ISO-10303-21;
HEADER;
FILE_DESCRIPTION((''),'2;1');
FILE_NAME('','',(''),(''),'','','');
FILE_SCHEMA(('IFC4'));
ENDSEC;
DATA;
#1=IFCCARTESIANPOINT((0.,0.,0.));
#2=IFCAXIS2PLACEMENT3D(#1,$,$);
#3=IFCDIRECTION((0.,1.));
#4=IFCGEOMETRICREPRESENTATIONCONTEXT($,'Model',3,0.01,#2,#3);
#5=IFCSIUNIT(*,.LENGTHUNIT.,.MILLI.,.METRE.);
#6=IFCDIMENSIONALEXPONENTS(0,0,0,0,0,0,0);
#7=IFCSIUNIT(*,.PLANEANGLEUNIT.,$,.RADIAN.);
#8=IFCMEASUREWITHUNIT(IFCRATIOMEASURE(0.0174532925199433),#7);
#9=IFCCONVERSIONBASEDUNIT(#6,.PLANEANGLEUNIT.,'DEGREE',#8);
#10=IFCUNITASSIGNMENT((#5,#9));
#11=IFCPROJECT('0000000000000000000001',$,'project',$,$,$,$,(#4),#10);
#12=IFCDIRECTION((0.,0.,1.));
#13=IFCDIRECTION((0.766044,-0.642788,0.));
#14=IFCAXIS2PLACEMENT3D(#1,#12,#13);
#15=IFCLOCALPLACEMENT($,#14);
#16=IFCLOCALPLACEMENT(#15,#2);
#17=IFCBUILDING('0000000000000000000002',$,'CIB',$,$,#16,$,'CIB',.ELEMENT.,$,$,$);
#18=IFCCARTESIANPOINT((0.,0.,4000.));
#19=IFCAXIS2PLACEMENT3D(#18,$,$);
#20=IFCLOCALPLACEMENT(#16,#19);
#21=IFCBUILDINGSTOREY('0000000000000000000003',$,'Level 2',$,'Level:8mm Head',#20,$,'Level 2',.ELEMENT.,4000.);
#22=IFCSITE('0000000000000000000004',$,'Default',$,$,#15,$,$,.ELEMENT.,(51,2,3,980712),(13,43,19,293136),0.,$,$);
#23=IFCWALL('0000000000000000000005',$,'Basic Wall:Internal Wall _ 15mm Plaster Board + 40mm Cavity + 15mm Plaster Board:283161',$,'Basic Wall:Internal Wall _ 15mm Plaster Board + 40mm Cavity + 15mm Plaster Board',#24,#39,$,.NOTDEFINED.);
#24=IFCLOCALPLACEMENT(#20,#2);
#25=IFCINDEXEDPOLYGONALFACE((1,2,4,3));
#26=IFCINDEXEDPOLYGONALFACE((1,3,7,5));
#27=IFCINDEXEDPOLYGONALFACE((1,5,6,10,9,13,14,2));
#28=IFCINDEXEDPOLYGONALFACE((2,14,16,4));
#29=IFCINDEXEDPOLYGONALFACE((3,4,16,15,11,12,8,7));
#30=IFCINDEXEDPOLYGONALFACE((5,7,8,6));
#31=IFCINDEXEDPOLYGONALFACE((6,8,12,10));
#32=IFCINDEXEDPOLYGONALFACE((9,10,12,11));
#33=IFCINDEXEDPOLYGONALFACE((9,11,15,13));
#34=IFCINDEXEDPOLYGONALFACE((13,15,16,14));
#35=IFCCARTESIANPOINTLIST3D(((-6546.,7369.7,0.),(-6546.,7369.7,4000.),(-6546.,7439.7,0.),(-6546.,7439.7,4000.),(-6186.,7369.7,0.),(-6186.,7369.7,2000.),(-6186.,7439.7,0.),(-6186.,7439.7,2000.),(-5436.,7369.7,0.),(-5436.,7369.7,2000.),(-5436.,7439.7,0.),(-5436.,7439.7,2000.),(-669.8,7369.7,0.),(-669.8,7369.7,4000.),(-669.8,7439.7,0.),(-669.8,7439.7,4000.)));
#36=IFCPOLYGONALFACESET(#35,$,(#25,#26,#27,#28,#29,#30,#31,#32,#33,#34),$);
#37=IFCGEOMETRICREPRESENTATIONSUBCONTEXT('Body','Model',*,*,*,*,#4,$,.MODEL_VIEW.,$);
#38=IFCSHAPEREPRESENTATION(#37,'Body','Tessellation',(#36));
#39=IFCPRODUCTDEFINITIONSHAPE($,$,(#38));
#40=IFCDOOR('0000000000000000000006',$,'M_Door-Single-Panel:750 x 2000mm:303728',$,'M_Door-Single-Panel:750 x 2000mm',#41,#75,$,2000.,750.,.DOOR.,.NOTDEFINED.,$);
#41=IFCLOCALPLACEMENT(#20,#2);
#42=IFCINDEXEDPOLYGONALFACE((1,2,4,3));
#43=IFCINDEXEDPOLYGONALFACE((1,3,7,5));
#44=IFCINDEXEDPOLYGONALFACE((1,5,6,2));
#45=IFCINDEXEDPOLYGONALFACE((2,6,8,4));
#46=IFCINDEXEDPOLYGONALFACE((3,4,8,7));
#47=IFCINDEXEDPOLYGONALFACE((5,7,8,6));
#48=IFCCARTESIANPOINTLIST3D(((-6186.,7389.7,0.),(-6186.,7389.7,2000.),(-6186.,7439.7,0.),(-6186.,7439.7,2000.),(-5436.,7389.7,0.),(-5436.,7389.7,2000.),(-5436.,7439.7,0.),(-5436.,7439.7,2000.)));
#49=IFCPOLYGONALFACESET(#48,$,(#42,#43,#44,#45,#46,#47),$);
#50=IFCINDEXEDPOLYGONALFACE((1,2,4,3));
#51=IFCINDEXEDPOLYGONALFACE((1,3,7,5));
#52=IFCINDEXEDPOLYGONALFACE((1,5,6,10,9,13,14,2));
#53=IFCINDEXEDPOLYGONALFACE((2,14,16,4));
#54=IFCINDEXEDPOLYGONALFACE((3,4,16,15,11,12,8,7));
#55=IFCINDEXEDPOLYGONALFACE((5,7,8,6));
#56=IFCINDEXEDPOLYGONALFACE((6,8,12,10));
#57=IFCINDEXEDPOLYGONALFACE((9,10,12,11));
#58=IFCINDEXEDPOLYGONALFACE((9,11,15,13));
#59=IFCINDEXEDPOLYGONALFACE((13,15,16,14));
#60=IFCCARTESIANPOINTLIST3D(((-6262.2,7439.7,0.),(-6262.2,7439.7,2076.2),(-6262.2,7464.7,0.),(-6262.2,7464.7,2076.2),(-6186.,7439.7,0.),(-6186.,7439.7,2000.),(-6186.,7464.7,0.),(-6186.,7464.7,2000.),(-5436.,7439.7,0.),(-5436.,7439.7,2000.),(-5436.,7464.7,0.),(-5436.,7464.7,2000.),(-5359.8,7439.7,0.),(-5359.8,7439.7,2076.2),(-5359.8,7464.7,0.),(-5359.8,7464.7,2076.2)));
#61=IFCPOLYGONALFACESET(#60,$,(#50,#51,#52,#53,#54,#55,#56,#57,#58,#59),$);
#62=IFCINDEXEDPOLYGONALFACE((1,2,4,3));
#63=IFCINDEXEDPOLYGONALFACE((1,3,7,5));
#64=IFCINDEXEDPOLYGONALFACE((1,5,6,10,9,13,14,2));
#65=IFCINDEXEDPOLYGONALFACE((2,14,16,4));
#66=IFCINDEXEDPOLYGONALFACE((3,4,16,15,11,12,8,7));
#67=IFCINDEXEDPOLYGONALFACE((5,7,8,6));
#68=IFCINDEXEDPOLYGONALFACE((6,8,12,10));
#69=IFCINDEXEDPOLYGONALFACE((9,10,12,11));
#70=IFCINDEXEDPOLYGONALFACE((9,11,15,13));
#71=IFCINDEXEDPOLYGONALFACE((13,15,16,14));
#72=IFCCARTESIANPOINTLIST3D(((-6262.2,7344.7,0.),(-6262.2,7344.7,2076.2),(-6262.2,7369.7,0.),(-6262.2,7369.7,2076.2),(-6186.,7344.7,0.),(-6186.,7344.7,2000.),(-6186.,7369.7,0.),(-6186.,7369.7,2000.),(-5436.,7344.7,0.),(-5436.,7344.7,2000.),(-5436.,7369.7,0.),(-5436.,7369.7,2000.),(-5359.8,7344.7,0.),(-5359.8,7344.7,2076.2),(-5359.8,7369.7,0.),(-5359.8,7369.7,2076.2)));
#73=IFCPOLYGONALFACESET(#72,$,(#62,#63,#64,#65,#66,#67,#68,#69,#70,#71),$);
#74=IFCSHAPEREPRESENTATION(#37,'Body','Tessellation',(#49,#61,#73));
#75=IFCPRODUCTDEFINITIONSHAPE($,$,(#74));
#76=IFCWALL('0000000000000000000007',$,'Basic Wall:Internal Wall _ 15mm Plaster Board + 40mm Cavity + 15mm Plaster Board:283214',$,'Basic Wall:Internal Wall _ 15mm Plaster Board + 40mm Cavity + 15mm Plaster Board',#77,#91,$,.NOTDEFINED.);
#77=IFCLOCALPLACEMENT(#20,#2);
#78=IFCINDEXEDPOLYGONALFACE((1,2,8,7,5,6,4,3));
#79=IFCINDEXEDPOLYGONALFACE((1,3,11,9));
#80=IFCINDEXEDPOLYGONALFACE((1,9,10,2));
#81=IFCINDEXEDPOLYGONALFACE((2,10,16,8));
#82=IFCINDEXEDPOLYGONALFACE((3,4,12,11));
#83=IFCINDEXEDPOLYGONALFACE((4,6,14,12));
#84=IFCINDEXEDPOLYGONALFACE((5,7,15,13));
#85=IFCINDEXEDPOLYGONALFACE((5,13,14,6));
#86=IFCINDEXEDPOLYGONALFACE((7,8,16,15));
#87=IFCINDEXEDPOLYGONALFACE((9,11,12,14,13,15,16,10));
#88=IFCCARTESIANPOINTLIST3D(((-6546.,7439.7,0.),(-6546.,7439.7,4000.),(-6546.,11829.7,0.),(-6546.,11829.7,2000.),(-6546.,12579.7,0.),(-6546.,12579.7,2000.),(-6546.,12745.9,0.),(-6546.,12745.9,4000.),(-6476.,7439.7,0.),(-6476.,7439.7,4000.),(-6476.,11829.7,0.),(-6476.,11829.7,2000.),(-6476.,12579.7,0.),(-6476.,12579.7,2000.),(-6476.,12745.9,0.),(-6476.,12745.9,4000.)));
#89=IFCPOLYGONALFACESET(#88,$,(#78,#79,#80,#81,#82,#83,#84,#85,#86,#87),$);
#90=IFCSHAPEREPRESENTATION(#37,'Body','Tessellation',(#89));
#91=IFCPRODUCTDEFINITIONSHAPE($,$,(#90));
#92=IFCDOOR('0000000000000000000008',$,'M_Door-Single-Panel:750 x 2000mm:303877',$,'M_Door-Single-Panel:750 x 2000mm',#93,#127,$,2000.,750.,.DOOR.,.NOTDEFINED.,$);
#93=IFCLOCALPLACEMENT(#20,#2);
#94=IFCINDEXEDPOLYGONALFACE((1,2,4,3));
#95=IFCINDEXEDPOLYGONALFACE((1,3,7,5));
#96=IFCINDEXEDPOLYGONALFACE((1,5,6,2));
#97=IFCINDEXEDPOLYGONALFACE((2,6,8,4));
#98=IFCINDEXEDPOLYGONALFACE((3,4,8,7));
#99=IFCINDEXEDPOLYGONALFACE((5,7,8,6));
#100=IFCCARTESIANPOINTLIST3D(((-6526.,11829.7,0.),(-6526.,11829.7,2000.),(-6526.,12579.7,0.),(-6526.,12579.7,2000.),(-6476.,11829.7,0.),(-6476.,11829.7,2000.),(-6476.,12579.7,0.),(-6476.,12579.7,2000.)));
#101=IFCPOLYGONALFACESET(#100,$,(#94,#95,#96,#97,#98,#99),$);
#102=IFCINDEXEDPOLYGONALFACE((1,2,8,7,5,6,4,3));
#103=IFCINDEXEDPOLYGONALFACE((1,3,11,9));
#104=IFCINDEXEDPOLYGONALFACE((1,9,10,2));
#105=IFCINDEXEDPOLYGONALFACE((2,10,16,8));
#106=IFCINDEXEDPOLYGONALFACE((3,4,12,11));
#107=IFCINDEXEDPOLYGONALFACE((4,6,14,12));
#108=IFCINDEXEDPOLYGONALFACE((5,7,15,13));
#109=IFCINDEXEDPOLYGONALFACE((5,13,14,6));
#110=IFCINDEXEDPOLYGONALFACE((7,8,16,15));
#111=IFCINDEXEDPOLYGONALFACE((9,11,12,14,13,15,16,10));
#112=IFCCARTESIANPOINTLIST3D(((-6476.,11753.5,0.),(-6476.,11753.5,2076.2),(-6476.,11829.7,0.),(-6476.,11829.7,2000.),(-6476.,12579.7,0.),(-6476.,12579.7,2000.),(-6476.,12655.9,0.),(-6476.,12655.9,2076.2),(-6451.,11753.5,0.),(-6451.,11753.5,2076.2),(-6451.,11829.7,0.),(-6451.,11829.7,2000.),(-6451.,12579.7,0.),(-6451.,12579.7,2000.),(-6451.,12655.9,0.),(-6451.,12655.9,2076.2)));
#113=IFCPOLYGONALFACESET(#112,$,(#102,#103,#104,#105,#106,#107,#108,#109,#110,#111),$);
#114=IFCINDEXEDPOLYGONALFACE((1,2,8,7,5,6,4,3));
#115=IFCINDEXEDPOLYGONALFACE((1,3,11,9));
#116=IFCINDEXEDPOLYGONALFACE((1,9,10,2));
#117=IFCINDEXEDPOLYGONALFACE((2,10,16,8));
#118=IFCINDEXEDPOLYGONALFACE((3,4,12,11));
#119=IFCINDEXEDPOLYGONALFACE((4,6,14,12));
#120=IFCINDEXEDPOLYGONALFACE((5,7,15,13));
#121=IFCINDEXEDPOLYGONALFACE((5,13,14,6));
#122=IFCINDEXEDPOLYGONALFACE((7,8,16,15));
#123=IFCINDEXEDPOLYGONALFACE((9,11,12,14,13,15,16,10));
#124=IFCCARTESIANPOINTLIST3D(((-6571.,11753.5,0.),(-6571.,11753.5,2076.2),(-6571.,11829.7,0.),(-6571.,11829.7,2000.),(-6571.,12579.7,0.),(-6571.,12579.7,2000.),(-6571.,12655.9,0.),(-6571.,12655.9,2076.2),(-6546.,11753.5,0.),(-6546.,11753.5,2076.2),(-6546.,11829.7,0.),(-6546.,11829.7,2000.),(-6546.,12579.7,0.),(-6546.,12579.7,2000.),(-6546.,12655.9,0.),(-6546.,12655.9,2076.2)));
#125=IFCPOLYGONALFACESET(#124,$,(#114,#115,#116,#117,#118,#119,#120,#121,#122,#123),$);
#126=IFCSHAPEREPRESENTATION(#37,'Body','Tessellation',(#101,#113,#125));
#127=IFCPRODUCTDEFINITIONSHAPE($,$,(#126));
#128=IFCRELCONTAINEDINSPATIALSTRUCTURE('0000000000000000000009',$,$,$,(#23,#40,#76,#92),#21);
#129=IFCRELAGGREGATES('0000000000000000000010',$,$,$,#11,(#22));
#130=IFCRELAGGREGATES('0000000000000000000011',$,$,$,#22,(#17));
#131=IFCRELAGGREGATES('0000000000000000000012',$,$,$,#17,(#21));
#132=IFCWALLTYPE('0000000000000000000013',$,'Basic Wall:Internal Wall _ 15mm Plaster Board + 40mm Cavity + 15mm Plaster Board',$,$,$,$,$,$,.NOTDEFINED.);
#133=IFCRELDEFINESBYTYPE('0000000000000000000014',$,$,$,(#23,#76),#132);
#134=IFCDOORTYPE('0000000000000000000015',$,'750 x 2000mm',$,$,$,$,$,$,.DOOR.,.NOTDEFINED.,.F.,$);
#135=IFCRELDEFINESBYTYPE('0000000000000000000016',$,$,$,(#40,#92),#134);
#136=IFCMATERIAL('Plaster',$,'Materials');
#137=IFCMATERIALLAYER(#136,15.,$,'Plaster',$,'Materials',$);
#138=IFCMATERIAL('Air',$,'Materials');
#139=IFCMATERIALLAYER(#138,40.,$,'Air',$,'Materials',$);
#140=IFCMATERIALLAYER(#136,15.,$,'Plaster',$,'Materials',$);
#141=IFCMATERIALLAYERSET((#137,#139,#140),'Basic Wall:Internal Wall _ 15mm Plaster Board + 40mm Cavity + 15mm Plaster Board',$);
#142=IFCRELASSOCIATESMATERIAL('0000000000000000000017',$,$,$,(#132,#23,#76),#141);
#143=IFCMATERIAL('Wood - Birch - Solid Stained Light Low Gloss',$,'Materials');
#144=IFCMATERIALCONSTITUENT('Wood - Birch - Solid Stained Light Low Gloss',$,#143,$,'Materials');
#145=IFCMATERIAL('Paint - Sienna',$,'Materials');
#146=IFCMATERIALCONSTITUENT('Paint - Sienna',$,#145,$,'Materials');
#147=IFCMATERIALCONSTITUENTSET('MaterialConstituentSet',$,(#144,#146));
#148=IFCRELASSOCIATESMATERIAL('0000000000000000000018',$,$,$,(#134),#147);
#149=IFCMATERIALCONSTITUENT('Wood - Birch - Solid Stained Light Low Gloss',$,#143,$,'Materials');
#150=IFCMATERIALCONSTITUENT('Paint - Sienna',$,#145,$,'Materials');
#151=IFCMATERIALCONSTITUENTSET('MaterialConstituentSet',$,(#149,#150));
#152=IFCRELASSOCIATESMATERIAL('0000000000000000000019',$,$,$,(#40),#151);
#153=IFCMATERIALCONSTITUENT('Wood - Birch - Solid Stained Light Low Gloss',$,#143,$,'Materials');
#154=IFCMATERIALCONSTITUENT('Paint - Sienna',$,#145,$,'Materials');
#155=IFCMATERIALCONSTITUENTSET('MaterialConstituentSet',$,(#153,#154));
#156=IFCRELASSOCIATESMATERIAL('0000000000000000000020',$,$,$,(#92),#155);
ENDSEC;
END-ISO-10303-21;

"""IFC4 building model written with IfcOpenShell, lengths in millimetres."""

from ifc_helpers import new_model, entity, si_unit, converted_unit, direction, frame, frame_2d, origin, origin_2d_with_axis, place, context, subcontext, project, spatial, polyline, rectangle, outline, extrude, source, transform, mapped, material, layer, layer_set, layer_usage, constituent, constituent_set, type_object, type_shapes, element, fill, save


model = new_model("IFC4")

# Units and contexts
model_context = context("Model", 3, precision=0.01, world=origin(), true_north=direction((0.0, 1.0)))
body_context = subcontext(model_context, "Body", "Model", "MODEL_VIEW")
ifc_project = project(units=[si_unit("LENGTHUNIT", "METRE", prefix="MILLI"), converted_unit("PLANEANGLEUNIT", "DEGREE", entity("IfcRatioMeasure", 0.0174532925199433), si_unit("PLANEANGLEUNIT", "RADIAN"), dimensions=[0, 0, 0, 0, 0, 0, 0])], contexts=[model_context])

# Site, building, storey
site_placement = place(None, frame((0.0, 0.0, 0.0), z_axis=(0.0, 0.0, 1.0), x_axis=(0.766044, -0.642788, 0.0)))
site = spatial("IfcSite", under=ifc_project, at=site_placement, Name="Default", CompositionType="ELEMENT", RefLatitude=(51, 2, 3, 980712), RefLongitude=(13, 43, 19, 293136), RefElevation=0.0)
building_placement = place(site_placement, origin())
building = spatial("IfcBuilding", under=site, at=building_placement, Name="CIB", LongName="CIB", CompositionType="ELEMENT")
storey_placement = place(building_placement, frame((0.0, 0.0, 4000.0)))
storey = spatial("IfcBuildingStorey", under=building, at=storey_placement, Name="Level 2", ObjectType="Level:8mm Head", LongName="Level 2", CompositionType="ELEMENT", Elevation=4000.0)

# Shared definitions
ifc_material_1 = material(Name="Plaster", Category="Materials")

# Walls, openings, doors
ifc_layer_1 = layer(ifc_material_1, 15.0, Name="Plaster", Category="Materials")
ifc_material_2 = material(Name="Air", Category="Materials")
ifc_layer_2 = layer(ifc_material_2, 40.0, Name="Air", Category="Materials")
ifc_layer_3 = layer(ifc_material_1, 15.0, Name="Plaster", Category="Materials")
ifc_layer_set_1 = layer_set([ifc_layer_1, ifc_layer_2, ifc_layer_3], Name="Basic Wall:Internal Wall _ 15mm Plaster Board + 40mm Cavity + 15mm Plaster Board")
ifc_layer_usage_1 = layer_usage(ifc_layer_set_1, "AXIS2", "NEGATIVE", 35.0)
wall_type_1 = type_object("IfcWallType", Name="Basic Wall:Internal Wall _ 15mm Plaster Board + 40mm Cavity + 15mm Plaster Board", PredefinedType="NOTDEFINED", material=ifc_layer_set_1)
wall_1_placement = place(storey_placement, frame((-669.8, 7404.7, 0.0), z_axis=(0.0, 0.0, 1.0), x_axis=(-1.0, 0.0, 0.0)))
wall_1 = element("IfcWall", 1, at=wall_1_placement, inside=storey, type_object=wall_type_1, material=ifc_layer_usage_1, Name="Basic Wall:Internal Wall _ 15mm Plaster Board + 40mm Cavity + 15mm Plaster Board:283161", ObjectType="Basic Wall:Internal Wall _ 15mm Plaster Board + 40mm Cavity + 15mm Plaster Board", PredefinedType="NOTDEFINED", context=body_context, shape_type="SweptSolid", body=[
    extrude(rectangle(XDim=5876.2, YDim=70.0, at=frame_2d((2938.1, 0.0), x_axis=(-1.0, 0.0))), origin(), (0.0, 0.0, 1.0), 4000.0),
])
opening_1_placement = place(wall_1_placement, frame((5516.2, 35.0, 0.0)))
opening_1 = element("IfcOpeningElement", 2, at=opening_1_placement, cuts=wall_1, ObjectType="Opening", PredefinedType="OPENING", context=body_context, shape_type="SweptSolid", body=[
    extrude(rectangle(XDim=750.0, YDim=2000.0, at=frame_2d((1000.0, 375.0), x_axis=(0.0, -1.0))), frame((0.0, 0.0, 0.0), z_axis=(0.0, -1.0, 0.0), x_axis=(0.0, 0.0, 1.0)), (0.0, 0.0, 1.0), 70.0),
])
ifc_material_3 = material(Name="Wood - Birch - Solid Stained Light Low Gloss", Category="Materials")
ifc_constituent_1 = constituent(ifc_material_3, Name="Wood - Birch - Solid Stained Light Low Gloss", Category="Materials")
ifc_material_4 = material(Name="Paint - Sienna", Category="Materials")
ifc_constituent_2 = constituent(ifc_material_4, Name="Paint - Sienna", Category="Materials")
ifc_constituent_set_1 = constituent_set(constituents=[ifc_constituent_1, ifc_constituent_2], Name="MaterialConstituentSet")
ifc_constituent_3 = constituent(ifc_material_3, Name="Wood - Birch - Solid Stained Light Low Gloss", Category="Materials")
ifc_constituent_4 = constituent(ifc_material_4, Name="Paint - Sienna", Category="Materials")
ifc_constituent_set_2 = constituent_set(constituents=[ifc_constituent_3, ifc_constituent_4], Name="MaterialConstituentSet")
door_type_1 = type_object("IfcDoorType", Name="750 x 2000mm", OperationType="NOTDEFINED", ParameterTakesPrecedence=False, PredefinedType="DOOR", material=ifc_constituent_set_2)
shared_shape_1 = source(origin(), body_context, "Body", "SweptSolid", [
    extrude(rectangle(XDim=750.0, YDim=50.0, at=origin_2d_with_axis()), frame((375.0, 45.0, 0.0)), (0.0, 0.0, 1.0), 2000.0),
    extrude(outline(polyline([(-451.2, -1057.2), (451.2, -1057.2), (451.2, 1019.0), (375.0, 1019.0), (375.0, -981.0), (-375.0, -981.0), (-375.0, 1019.0), (-451.2, 1019.0), (-451.2, -1057.2)])), frame((375.0, 95.0, 1019.0), z_axis=(0.0, -1.0, 0.0), x_axis=(-1.0, 0.0, 0.0)), (0.0, 0.0, 1.0), 25.0),
    extrude(outline(polyline([(-1057.2, -451.2), (1019.0, -451.2), (1019.0, -375.0), (-981.0, -375.0), (-981.0, 375.0), (1019.0, 375.0), (1019.0, 451.2), (-1057.2, 451.2), (-1057.2, -451.2)])), frame((375.0, 0.0, 1019.0), z_axis=(0.0, -1.0, 0.0), x_axis=(0.0, 0.0, -1.0)), (0.0, 0.0, 1.0), 25.0),
])
type_shapes(door_type_1, [shared_shape_1])
door_1_placement = place(opening_1_placement, frame((0.0, 0.0, 0.0), z_axis=(0.0, 0.0, 1.0), x_axis=(-1.0, 0.0, 0.0)))
door_1 = element("IfcDoor", 3, at=door_1_placement, inside=storey, type_object=door_type_1, material=ifc_constituent_set_1, Name="M_Door-Single-Panel:750 x 2000mm:303728", ObjectType="M_Door-Single-Panel:750 x 2000mm", OperationType="NOTDEFINED", OverallHeight=2000.0, OverallWidth=750.0, PredefinedType="DOOR", context=body_context, shape_type="MappedRepresentation", body=[
    mapped(shared_shape_1, transform((0.0, 0.0, 0.0), scale=1.0)),
])
fill(opening_1, door_1)
ifc_layer_usage_2 = layer_usage(ifc_layer_set_1, "AXIS2", "NEGATIVE", 35.0)
wall_2_placement = place(storey_placement, frame((-6511.0, 7439.7, 0.0), z_axis=(0.0, 0.0, 1.0), x_axis=(0.0, 1.0, 0.0)))
wall_2 = element("IfcWall", 4, at=wall_2_placement, inside=storey, type_object=wall_type_1, material=ifc_layer_usage_2, Name="Basic Wall:Internal Wall _ 15mm Plaster Board + 40mm Cavity + 15mm Plaster Board:283214", ObjectType="Basic Wall:Internal Wall _ 15mm Plaster Board + 40mm Cavity + 15mm Plaster Board", PredefinedType="NOTDEFINED", context=body_context, shape_type="SweptSolid", body=[
    extrude(rectangle(XDim=5306.2, YDim=70.0, at=frame_2d((2653.1, 0.0), x_axis=(-1.0, 0.0))), origin(), (0.0, 0.0, 1.0), 4000.0),
])
opening_2_placement = place(wall_2_placement, frame((5140.0, 35.0, 0.0)))
opening_2 = element("IfcOpeningElement", 5, at=opening_2_placement, cuts=wall_2, ObjectType="Opening", PredefinedType="OPENING", context=body_context, shape_type="SweptSolid", body=[
    extrude(rectangle(XDim=750.0, YDim=2000.0, at=frame_2d((1000.0, 375.0), x_axis=(0.0, -1.0))), frame((0.0, 0.0, 0.0), z_axis=(0.0, -1.0, 0.0), x_axis=(0.0, 0.0, 1.0)), (0.0, 0.0, 1.0), 70.0),
])
ifc_constituent_5 = constituent(ifc_material_3, Name="Wood - Birch - Solid Stained Light Low Gloss", Category="Materials")
ifc_constituent_6 = constituent(ifc_material_4, Name="Paint - Sienna", Category="Materials")
ifc_constituent_set_3 = constituent_set(constituents=[ifc_constituent_5, ifc_constituent_6], Name="MaterialConstituentSet")
door_2_placement = place(opening_2_placement, frame((0.0, 0.0, 0.0), z_axis=(0.0, 0.0, 1.0), x_axis=(-1.0, 0.0, 0.0)))
door_2 = element("IfcDoor", 6, at=door_2_placement, inside=storey, type_object=door_type_1, material=ifc_constituent_set_3, Name="M_Door-Single-Panel:750 x 2000mm:303877", ObjectType="M_Door-Single-Panel:750 x 2000mm", OperationType="NOTDEFINED", OverallHeight=2000.0, OverallWidth=750.0, PredefinedType="DOOR", context=body_context, shape_type="MappedRepresentation", body=[
    mapped(shared_shape_1, transform((0.0, 0.0, 0.0), scale=1.0)),
])
fill(opening_2, door_2)

save(model, "model.ifc")
